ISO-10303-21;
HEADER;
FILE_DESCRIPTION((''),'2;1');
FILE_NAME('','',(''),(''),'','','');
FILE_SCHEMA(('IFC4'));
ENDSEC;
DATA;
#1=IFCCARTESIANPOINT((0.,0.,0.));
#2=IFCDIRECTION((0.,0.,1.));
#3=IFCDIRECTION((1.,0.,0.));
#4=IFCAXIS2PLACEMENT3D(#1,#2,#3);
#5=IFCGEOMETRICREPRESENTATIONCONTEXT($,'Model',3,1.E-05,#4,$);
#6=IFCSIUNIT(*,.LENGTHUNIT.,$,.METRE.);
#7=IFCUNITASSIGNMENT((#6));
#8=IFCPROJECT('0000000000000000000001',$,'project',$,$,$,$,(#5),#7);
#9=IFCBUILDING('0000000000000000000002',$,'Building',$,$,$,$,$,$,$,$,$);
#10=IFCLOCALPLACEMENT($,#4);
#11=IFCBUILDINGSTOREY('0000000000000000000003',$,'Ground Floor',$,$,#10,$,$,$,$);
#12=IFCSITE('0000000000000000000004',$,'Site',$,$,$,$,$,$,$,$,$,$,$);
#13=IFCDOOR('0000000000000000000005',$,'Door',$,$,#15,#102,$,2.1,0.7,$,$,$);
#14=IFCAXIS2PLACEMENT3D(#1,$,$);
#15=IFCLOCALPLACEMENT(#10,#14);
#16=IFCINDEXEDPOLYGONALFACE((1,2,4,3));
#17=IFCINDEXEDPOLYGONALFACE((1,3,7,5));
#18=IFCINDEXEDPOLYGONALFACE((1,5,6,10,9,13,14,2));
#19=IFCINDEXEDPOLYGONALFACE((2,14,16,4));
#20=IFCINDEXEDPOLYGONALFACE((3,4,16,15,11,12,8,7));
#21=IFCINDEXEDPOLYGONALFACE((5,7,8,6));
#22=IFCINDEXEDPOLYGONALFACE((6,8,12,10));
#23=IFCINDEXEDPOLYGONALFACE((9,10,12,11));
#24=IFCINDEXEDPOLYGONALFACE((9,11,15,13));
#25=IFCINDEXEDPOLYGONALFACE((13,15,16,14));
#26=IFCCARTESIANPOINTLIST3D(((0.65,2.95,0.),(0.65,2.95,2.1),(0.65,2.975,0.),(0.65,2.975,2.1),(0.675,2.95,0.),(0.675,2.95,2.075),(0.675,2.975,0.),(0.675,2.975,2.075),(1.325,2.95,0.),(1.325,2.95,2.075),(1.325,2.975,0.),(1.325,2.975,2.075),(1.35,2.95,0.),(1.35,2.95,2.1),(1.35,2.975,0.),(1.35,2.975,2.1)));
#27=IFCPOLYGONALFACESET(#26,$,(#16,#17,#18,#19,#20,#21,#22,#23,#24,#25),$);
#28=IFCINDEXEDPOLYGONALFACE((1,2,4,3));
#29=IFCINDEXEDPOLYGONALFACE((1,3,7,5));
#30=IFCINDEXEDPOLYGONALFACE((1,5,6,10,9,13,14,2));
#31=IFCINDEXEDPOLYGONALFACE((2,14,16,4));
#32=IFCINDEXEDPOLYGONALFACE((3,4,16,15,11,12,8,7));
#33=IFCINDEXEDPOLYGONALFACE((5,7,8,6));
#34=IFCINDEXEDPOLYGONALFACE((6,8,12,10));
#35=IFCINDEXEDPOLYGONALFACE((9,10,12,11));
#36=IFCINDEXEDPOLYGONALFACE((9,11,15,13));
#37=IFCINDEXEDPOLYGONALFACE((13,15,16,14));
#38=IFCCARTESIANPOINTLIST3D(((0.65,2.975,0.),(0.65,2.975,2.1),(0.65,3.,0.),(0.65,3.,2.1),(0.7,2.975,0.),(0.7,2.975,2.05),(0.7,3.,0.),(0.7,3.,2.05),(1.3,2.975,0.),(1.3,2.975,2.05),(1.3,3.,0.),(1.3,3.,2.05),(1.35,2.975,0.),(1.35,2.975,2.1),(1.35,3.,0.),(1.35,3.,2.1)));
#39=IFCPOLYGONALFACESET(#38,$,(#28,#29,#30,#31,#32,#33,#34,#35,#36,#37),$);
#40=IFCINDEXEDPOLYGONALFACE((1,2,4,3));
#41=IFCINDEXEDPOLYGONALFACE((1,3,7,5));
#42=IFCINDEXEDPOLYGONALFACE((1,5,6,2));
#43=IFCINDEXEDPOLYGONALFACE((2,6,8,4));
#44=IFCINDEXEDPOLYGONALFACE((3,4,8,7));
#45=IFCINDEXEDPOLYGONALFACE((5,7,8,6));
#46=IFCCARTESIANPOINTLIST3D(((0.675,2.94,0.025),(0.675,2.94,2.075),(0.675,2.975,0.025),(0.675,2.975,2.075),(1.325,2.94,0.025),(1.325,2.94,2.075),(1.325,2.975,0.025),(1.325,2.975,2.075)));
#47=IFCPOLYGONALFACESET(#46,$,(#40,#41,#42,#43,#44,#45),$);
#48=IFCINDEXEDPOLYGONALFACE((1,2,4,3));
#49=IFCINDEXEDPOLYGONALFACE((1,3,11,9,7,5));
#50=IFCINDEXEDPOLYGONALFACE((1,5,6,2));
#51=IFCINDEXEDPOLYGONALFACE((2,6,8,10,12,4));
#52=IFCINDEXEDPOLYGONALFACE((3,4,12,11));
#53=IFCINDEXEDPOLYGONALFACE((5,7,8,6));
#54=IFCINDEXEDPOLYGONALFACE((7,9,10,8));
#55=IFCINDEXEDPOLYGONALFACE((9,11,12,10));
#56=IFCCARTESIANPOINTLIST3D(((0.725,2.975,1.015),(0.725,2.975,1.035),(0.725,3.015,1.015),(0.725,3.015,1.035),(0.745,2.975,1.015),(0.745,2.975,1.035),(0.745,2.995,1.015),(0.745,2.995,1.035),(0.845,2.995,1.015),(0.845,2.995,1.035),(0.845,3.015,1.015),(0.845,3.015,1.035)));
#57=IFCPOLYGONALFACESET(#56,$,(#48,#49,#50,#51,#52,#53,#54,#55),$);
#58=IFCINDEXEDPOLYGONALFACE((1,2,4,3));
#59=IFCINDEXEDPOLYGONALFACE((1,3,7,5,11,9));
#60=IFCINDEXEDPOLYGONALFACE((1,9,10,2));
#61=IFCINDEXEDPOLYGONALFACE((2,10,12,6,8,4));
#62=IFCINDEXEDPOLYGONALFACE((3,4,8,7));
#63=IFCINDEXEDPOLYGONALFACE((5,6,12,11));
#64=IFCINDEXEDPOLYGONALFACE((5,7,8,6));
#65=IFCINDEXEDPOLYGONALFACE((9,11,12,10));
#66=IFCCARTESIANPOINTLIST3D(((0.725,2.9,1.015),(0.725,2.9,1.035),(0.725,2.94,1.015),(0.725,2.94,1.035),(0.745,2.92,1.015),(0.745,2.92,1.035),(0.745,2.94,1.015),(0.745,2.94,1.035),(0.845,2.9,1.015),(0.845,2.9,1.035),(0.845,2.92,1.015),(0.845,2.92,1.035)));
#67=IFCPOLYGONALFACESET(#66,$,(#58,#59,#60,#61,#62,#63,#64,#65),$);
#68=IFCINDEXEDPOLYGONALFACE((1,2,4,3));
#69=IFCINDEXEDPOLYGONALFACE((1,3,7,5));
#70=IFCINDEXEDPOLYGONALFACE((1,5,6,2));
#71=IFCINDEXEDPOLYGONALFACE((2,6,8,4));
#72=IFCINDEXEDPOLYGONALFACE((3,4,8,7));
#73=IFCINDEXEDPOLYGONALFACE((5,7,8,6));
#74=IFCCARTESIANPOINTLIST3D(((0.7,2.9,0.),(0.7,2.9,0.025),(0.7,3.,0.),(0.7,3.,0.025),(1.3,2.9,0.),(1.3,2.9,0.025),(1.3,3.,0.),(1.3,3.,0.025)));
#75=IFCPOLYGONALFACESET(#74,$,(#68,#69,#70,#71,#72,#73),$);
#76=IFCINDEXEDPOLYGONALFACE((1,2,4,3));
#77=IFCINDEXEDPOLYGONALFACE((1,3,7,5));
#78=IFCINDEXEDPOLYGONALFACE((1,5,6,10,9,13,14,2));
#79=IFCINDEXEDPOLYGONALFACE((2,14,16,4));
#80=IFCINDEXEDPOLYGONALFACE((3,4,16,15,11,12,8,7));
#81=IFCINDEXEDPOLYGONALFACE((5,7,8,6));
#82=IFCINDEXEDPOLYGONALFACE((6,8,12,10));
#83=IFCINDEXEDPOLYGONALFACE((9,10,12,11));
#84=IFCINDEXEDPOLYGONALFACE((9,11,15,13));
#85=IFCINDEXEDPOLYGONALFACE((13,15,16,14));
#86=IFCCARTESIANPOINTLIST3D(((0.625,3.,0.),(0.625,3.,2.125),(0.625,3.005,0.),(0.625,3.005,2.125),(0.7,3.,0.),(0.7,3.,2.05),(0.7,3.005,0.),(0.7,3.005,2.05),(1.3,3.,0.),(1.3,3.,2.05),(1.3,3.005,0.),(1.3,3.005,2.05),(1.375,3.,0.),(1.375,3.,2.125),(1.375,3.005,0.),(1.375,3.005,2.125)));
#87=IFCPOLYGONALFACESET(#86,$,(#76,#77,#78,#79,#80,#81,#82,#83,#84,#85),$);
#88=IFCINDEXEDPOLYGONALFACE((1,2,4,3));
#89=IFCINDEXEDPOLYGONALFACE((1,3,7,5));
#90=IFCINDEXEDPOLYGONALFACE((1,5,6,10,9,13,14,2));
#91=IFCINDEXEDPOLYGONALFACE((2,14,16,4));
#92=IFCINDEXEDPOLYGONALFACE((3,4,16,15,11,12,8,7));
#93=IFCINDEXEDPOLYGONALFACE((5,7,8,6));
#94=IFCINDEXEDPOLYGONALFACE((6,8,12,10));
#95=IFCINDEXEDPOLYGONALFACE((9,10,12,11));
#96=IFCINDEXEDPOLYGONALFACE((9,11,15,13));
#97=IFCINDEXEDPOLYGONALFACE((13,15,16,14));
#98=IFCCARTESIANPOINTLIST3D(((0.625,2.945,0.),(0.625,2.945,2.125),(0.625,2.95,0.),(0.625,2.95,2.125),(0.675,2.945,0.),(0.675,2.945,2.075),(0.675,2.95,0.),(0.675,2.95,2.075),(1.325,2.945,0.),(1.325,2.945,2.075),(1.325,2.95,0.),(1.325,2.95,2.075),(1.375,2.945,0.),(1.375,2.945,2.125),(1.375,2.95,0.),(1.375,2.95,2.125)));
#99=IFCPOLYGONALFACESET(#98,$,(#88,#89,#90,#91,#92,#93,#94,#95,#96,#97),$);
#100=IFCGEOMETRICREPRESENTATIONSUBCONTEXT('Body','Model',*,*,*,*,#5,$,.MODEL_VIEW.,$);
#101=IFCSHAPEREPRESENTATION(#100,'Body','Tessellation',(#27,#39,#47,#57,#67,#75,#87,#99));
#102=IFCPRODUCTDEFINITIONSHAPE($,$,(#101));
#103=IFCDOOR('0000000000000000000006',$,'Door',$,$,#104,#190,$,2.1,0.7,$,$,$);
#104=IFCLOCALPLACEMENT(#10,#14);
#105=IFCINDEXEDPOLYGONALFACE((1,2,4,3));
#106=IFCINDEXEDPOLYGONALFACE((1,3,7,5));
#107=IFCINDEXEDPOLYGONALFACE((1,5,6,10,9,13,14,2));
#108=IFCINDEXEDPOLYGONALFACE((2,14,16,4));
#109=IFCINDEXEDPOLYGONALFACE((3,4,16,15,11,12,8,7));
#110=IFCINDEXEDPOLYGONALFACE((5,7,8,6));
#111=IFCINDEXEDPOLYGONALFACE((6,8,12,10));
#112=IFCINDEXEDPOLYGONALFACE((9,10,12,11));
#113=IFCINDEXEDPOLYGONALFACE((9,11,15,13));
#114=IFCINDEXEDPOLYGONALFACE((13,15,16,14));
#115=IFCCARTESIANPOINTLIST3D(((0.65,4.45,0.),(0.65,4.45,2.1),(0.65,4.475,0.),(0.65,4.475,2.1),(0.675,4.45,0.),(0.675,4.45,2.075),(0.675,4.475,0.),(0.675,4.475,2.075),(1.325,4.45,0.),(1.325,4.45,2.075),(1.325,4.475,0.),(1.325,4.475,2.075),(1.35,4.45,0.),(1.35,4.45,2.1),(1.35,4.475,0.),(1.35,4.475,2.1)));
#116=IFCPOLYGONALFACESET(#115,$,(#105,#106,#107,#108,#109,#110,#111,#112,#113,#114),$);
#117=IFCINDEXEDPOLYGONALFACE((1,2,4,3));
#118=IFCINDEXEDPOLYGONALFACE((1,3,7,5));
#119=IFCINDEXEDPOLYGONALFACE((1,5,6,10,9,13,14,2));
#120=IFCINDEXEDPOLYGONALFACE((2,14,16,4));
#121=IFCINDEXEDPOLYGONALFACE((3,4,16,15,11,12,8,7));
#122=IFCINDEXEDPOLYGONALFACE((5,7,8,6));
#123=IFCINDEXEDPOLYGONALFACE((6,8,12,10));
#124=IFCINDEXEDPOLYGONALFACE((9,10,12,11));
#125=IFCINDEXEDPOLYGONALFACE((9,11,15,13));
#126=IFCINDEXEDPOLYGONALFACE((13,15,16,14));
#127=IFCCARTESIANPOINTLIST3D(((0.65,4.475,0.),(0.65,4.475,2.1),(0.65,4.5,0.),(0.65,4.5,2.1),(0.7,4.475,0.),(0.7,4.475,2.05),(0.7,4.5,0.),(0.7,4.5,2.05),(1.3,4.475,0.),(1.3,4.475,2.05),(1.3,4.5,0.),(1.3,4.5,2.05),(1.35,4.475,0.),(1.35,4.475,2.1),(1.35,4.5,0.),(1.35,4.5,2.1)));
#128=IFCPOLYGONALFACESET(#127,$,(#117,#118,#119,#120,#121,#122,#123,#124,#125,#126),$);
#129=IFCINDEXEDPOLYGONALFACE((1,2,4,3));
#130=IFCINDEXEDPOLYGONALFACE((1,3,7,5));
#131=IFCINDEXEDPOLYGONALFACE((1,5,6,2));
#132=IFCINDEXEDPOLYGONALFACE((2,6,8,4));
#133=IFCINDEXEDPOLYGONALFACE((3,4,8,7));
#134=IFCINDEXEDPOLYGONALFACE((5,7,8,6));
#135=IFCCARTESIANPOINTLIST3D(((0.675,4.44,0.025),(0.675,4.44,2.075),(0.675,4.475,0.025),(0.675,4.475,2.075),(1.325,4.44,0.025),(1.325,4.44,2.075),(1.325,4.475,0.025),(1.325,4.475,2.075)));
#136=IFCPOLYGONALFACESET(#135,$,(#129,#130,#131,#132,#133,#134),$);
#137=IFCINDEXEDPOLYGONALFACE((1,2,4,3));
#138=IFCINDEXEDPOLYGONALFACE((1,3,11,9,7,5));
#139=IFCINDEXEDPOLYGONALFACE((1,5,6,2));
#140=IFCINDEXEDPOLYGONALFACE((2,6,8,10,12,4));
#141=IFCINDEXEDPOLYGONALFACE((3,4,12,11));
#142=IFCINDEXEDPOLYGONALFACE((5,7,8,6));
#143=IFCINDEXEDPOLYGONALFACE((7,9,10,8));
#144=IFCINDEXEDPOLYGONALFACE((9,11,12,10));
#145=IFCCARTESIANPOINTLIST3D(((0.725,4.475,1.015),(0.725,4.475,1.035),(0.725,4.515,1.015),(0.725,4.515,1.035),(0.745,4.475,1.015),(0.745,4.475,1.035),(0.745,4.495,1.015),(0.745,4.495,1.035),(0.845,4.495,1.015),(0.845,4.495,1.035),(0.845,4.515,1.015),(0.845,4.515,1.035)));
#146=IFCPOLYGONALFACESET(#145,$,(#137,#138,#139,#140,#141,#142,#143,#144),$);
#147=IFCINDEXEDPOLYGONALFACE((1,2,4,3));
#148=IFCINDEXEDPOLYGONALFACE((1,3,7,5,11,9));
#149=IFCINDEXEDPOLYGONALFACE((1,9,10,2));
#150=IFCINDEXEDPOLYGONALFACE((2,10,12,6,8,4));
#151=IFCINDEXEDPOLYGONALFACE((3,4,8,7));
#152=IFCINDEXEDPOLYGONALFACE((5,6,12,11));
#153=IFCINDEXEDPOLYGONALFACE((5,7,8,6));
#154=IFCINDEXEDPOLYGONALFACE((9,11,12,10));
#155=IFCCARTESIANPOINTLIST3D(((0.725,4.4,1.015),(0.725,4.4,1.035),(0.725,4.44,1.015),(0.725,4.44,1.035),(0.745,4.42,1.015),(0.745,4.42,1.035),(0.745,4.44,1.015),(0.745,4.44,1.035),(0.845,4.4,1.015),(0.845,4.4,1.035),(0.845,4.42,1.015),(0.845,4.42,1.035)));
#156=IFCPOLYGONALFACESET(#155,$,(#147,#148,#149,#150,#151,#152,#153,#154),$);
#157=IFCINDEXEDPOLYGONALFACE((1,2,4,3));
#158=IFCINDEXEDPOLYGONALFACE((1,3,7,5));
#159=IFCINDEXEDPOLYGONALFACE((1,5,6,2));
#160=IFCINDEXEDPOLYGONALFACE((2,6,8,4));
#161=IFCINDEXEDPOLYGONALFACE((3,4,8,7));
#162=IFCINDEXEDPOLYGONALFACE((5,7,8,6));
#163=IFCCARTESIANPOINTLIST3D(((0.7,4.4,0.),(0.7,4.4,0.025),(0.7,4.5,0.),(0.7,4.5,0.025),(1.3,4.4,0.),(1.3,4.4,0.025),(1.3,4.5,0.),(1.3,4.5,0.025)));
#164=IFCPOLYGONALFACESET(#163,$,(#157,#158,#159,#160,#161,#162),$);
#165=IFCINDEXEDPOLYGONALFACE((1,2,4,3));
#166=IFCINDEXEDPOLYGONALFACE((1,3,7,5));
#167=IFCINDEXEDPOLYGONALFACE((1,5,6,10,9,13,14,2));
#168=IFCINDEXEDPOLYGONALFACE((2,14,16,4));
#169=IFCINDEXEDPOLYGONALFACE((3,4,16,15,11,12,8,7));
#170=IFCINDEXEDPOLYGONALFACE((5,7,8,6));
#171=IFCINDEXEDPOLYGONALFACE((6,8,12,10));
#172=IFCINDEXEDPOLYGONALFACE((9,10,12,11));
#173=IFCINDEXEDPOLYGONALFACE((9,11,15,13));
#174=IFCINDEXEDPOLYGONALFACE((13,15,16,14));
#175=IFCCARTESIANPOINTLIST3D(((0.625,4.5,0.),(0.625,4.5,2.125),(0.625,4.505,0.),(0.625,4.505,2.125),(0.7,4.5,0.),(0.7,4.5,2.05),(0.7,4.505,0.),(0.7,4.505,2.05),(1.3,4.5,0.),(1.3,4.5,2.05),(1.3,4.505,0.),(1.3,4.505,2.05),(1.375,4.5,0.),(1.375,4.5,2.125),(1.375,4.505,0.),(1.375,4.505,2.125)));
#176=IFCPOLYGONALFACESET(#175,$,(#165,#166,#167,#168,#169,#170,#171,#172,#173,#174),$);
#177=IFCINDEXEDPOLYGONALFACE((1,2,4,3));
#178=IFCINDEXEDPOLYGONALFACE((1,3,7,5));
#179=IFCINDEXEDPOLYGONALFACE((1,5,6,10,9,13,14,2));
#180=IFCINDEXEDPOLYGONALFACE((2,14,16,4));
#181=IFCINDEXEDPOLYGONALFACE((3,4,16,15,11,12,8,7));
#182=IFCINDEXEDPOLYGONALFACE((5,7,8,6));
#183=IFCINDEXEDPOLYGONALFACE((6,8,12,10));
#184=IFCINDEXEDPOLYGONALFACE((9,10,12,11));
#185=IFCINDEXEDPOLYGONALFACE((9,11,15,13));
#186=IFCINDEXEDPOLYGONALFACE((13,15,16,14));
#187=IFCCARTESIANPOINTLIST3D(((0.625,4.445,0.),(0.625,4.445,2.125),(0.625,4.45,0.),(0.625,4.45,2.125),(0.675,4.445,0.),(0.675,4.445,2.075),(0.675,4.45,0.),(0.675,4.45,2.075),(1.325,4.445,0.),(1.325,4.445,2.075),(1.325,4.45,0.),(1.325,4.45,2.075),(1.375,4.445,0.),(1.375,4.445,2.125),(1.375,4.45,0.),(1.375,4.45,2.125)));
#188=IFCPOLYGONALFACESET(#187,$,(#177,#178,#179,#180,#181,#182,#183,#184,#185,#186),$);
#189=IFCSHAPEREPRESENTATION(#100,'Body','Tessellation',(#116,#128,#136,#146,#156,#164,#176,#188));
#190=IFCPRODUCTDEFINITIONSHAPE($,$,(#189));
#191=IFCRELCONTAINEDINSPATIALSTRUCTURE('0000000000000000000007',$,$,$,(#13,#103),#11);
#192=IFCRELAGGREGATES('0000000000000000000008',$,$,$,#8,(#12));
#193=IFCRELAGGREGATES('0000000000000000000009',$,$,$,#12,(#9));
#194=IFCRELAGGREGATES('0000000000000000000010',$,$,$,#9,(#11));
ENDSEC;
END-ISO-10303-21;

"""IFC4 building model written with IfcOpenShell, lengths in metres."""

from ifc_helpers import new_model, si_unit, frame, origin_with_axes, place, context, subcontext, project, spatial, line, indexed_curve, outline, extrude, element, save


model = new_model("IFC4")

# Units and contexts
model_context = context("Model", 3, precision=1e-05, world=origin_with_axes())
body_context = subcontext(model_context, "Body", "Model", "MODEL_VIEW")
ifc_project = project(units=[si_unit("LENGTHUNIT", "METRE")], contexts=[model_context])

# Site, building, storey
site = spatial("IfcSite", under=ifc_project, Name="Site")
building = spatial("IfcBuilding", under=site, Name="Building")
storey_placement = place(None, origin_with_axes())
storey = spatial("IfcBuildingStorey", under=building, at=storey_placement, Name="Ground Floor")

# Doors
door_1_placement = place(storey_placement, frame((1.35, 3.0, 0.0), z_axis=(0.0, 0.0, 1.0), x_axis=(-1.0, 0.0, 0.0)))
element("IfcDoor", 1, at=door_1_placement, inside=storey, Name="Door", OverallHeight=2.1, OverallWidth=0.7, context=body_context, shape_type="SweptSolid", body=[
    extrude(outline(indexed_curve([(0.0, 0.0), (0.0, 2.1), (0.7, 2.1), (0.7, 0.0), (0.675, 0.0), (0.675, 2.075), (0.025, 2.075), (0.025, 0.0)], segments=[line(1, 2, 3, 4, 5, 6, 7, 8, 1)])), frame((0.0, 0.025, 0.0), z_axis=(0.0, -1.0, 0.0), x_axis=(1.0, 0.0, 0.0)), (0.0, 0.0, -1.0), 0.025),
    extrude(outline(indexed_curve([(0.0, 0.0), (0.0, 2.1), (0.7, 2.1), (0.7, 0.0), (0.65, 0.0), (0.65, 2.05), (0.05, 2.05), (0.05, 0.0)], segments=[line(1, 2, 3, 4, 5, 6, 7, 8, 1)])), frame((0.0, 0.0, 0.0), z_axis=(0.0, -1.0, 0.0), x_axis=(1.0, 0.0, 0.0)), (0.0, 0.0, -1.0), 0.025),
    extrude(outline(indexed_curve([(0.0, 0.0), (0.65, 0.0), (0.65, 0.035), (0.0, 0.035)], segments=[line(1, 2, 3, 4, 1)])), frame((0.025, 0.025, 0.025), z_axis=(0.0, 0.0, 1.0), x_axis=(1.0, 0.0, 0.0)), (0.0, 0.0, 1.0), 2.05),
    extrude(outline(indexed_curve([(0.0, 0.0), (0.0, -0.04), (-0.12, -0.04), (-0.12, -0.02), (-0.02, -0.02), (-0.02, 0.0)], segments=[line(1, 2, 3, 4, 5, 6, 1)])), frame((0.625, 0.025, 1.015), z_axis=(0.0, 0.0, 1.0), x_axis=(1.0, 0.0, 0.0)), (0.0, 0.0, 1.0), 0.02),
    extrude(outline(indexed_curve([(0.0, 0.0), (0.0, 0.04), (-0.12, 0.04), (-0.12, 0.02), (-0.02, 0.02), (-0.02, 0.0)], segments=[line(1, 2, 3, 4, 5, 6, 1)])), frame((0.625, 0.06, 1.015), z_axis=(0.0, 0.0, 1.0), x_axis=(1.0, 0.0, 0.0)), (0.0, 0.0, 1.0), 0.02),
    extrude(outline(indexed_curve([(0.0, 0.0), (0.6, 0.0), (0.6, 0.1), (0.0, 0.1)], segments=[line(1, 2, 3, 4, 1)])), frame((0.05, 0.0, 0.0), z_axis=(0.0, 0.0, 1.0), x_axis=(1.0, 0.0, 0.0)), (0.0, 0.0, 1.0), 0.025),
    extrude(outline(indexed_curve([(0.0, 0.0), (0.0, 2.125), (0.75, 2.125), (0.75, 0.0), (0.675, 0.0), (0.675, 2.05), (0.075, 2.05), (0.075, 0.0)], segments=[line(1, 2, 3, 4, 5, 6, 7, 8, 1)])), frame((-0.025, -0.005, 0.0), z_axis=(0.0, -1.0, 0.0), x_axis=(1.0, 0.0, 0.0)), (0.0, 0.0, -1.0), 0.005),
    extrude(outline(indexed_curve([(0.0, 0.0), (0.0, 2.125), (0.75, 2.125), (0.75, 0.0), (0.7, 0.0), (0.7, 2.075), (0.05, 2.075), (0.05, 0.0)], segments=[line(1, 2, 3, 4, 5, 6, 7, 8, 1)])), frame((-0.025, 0.05, 0.0), z_axis=(0.0, -1.0, 0.0), x_axis=(1.0, 0.0, 0.0)), (0.0, 0.0, -1.0), 0.005),
])
door_2_placement = place(storey_placement, frame((1.35, 4.5, 0.0), z_axis=(0.0, 0.0, 1.0), x_axis=(-1.0, 0.0, 0.0)))
element("IfcDoor", 2, at=door_2_placement, inside=storey, Name="Door", OverallHeight=2.1, OverallWidth=0.7, context=body_context, shape_type="SweptSolid", body=[
    extrude(outline(indexed_curve([(0.0, 0.0), (0.0, 2.1), (0.7, 2.1), (0.7, 0.0), (0.675, 0.0), (0.675, 2.075), (0.025, 2.075), (0.025, 0.0)], segments=[line(1, 2, 3, 4, 5, 6, 7, 8, 1)])), frame((0.0, 0.025, 0.0), z_axis=(0.0, -1.0, 0.0), x_axis=(1.0, 0.0, 0.0)), (0.0, 0.0, -1.0), 0.025),
    extrude(outline(indexed_curve([(0.0, 0.0), (0.0, 2.1), (0.7, 2.1), (0.7, 0.0), (0.65, 0.0), (0.65, 2.05), (0.05, 2.05), (0.05, 0.0)], segments=[line(1, 2, 3, 4, 5, 6, 7, 8, 1)])), frame((0.0, 0.0, 0.0), z_axis=(0.0, -1.0, 0.0), x_axis=(1.0, 0.0, 0.0)), (0.0, 0.0, -1.0), 0.025),
    extrude(outline(indexed_curve([(0.0, 0.0), (0.65, 0.0), (0.65, 0.035), (0.0, 0.035)], segments=[line(1, 2, 3, 4, 1)])), frame((0.025, 0.025, 0.025), z_axis=(0.0, 0.0, 1.0), x_axis=(1.0, 0.0, 0.0)), (0.0, 0.0, 1.0), 2.05),
    extrude(outline(indexed_curve([(0.0, 0.0), (0.0, -0.04), (-0.12, -0.04), (-0.12, -0.02), (-0.02, -0.02), (-0.02, 0.0)], segments=[line(1, 2, 3, 4, 5, 6, 1)])), frame((0.625, 0.025, 1.015), z_axis=(0.0, 0.0, 1.0), x_axis=(1.0, 0.0, 0.0)), (0.0, 0.0, 1.0), 0.02),
    extrude(outline(indexed_curve([(0.0, 0.0), (0.0, 0.04), (-0.12, 0.04), (-0.12, 0.02), (-0.02, 0.02), (-0.02, 0.0)], segments=[line(1, 2, 3, 4, 5, 6, 1)])), frame((0.625, 0.06, 1.015), z_axis=(0.0, 0.0, 1.0), x_axis=(1.0, 0.0, 0.0)), (0.0, 0.0, 1.0), 0.02),
    extrude(outline(indexed_curve([(0.0, 0.0), (0.6, 0.0), (0.6, 0.1), (0.0, 0.1)], segments=[line(1, 2, 3, 4, 1)])), frame((0.05, 0.0, 0.0), z_axis=(0.0, 0.0, 1.0), x_axis=(1.0, 0.0, 0.0)), (0.0, 0.0, 1.0), 0.025),
    extrude(outline(indexed_curve([(0.0, 0.0), (0.0, 2.125), (0.75, 2.125), (0.75, 0.0), (0.675, 0.0), (0.675, 2.05), (0.075, 2.05), (0.075, 0.0)], segments=[line(1, 2, 3, 4, 5, 6, 7, 8, 1)])), frame((-0.025, -0.005, 0.0), z_axis=(0.0, -1.0, 0.0), x_axis=(1.0, 0.0, 0.0)), (0.0, 0.0, -1.0), 0.005),
    extrude(outline(indexed_curve([(0.0, 0.0), (0.0, 2.125), (0.75, 2.125), (0.75, 0.0), (0.7, 0.0), (0.7, 2.075), (0.05, 2.075), (0.05, 0.0)], segments=[line(1, 2, 3, 4, 5, 6, 7, 8, 1)])), frame((-0.025, 0.05, 0.0), z_axis=(0.0, -1.0, 0.0), x_axis=(1.0, 0.0, 0.0)), (0.0, 0.0, -1.0), 0.005),
])

save(model, "model.ifc")
